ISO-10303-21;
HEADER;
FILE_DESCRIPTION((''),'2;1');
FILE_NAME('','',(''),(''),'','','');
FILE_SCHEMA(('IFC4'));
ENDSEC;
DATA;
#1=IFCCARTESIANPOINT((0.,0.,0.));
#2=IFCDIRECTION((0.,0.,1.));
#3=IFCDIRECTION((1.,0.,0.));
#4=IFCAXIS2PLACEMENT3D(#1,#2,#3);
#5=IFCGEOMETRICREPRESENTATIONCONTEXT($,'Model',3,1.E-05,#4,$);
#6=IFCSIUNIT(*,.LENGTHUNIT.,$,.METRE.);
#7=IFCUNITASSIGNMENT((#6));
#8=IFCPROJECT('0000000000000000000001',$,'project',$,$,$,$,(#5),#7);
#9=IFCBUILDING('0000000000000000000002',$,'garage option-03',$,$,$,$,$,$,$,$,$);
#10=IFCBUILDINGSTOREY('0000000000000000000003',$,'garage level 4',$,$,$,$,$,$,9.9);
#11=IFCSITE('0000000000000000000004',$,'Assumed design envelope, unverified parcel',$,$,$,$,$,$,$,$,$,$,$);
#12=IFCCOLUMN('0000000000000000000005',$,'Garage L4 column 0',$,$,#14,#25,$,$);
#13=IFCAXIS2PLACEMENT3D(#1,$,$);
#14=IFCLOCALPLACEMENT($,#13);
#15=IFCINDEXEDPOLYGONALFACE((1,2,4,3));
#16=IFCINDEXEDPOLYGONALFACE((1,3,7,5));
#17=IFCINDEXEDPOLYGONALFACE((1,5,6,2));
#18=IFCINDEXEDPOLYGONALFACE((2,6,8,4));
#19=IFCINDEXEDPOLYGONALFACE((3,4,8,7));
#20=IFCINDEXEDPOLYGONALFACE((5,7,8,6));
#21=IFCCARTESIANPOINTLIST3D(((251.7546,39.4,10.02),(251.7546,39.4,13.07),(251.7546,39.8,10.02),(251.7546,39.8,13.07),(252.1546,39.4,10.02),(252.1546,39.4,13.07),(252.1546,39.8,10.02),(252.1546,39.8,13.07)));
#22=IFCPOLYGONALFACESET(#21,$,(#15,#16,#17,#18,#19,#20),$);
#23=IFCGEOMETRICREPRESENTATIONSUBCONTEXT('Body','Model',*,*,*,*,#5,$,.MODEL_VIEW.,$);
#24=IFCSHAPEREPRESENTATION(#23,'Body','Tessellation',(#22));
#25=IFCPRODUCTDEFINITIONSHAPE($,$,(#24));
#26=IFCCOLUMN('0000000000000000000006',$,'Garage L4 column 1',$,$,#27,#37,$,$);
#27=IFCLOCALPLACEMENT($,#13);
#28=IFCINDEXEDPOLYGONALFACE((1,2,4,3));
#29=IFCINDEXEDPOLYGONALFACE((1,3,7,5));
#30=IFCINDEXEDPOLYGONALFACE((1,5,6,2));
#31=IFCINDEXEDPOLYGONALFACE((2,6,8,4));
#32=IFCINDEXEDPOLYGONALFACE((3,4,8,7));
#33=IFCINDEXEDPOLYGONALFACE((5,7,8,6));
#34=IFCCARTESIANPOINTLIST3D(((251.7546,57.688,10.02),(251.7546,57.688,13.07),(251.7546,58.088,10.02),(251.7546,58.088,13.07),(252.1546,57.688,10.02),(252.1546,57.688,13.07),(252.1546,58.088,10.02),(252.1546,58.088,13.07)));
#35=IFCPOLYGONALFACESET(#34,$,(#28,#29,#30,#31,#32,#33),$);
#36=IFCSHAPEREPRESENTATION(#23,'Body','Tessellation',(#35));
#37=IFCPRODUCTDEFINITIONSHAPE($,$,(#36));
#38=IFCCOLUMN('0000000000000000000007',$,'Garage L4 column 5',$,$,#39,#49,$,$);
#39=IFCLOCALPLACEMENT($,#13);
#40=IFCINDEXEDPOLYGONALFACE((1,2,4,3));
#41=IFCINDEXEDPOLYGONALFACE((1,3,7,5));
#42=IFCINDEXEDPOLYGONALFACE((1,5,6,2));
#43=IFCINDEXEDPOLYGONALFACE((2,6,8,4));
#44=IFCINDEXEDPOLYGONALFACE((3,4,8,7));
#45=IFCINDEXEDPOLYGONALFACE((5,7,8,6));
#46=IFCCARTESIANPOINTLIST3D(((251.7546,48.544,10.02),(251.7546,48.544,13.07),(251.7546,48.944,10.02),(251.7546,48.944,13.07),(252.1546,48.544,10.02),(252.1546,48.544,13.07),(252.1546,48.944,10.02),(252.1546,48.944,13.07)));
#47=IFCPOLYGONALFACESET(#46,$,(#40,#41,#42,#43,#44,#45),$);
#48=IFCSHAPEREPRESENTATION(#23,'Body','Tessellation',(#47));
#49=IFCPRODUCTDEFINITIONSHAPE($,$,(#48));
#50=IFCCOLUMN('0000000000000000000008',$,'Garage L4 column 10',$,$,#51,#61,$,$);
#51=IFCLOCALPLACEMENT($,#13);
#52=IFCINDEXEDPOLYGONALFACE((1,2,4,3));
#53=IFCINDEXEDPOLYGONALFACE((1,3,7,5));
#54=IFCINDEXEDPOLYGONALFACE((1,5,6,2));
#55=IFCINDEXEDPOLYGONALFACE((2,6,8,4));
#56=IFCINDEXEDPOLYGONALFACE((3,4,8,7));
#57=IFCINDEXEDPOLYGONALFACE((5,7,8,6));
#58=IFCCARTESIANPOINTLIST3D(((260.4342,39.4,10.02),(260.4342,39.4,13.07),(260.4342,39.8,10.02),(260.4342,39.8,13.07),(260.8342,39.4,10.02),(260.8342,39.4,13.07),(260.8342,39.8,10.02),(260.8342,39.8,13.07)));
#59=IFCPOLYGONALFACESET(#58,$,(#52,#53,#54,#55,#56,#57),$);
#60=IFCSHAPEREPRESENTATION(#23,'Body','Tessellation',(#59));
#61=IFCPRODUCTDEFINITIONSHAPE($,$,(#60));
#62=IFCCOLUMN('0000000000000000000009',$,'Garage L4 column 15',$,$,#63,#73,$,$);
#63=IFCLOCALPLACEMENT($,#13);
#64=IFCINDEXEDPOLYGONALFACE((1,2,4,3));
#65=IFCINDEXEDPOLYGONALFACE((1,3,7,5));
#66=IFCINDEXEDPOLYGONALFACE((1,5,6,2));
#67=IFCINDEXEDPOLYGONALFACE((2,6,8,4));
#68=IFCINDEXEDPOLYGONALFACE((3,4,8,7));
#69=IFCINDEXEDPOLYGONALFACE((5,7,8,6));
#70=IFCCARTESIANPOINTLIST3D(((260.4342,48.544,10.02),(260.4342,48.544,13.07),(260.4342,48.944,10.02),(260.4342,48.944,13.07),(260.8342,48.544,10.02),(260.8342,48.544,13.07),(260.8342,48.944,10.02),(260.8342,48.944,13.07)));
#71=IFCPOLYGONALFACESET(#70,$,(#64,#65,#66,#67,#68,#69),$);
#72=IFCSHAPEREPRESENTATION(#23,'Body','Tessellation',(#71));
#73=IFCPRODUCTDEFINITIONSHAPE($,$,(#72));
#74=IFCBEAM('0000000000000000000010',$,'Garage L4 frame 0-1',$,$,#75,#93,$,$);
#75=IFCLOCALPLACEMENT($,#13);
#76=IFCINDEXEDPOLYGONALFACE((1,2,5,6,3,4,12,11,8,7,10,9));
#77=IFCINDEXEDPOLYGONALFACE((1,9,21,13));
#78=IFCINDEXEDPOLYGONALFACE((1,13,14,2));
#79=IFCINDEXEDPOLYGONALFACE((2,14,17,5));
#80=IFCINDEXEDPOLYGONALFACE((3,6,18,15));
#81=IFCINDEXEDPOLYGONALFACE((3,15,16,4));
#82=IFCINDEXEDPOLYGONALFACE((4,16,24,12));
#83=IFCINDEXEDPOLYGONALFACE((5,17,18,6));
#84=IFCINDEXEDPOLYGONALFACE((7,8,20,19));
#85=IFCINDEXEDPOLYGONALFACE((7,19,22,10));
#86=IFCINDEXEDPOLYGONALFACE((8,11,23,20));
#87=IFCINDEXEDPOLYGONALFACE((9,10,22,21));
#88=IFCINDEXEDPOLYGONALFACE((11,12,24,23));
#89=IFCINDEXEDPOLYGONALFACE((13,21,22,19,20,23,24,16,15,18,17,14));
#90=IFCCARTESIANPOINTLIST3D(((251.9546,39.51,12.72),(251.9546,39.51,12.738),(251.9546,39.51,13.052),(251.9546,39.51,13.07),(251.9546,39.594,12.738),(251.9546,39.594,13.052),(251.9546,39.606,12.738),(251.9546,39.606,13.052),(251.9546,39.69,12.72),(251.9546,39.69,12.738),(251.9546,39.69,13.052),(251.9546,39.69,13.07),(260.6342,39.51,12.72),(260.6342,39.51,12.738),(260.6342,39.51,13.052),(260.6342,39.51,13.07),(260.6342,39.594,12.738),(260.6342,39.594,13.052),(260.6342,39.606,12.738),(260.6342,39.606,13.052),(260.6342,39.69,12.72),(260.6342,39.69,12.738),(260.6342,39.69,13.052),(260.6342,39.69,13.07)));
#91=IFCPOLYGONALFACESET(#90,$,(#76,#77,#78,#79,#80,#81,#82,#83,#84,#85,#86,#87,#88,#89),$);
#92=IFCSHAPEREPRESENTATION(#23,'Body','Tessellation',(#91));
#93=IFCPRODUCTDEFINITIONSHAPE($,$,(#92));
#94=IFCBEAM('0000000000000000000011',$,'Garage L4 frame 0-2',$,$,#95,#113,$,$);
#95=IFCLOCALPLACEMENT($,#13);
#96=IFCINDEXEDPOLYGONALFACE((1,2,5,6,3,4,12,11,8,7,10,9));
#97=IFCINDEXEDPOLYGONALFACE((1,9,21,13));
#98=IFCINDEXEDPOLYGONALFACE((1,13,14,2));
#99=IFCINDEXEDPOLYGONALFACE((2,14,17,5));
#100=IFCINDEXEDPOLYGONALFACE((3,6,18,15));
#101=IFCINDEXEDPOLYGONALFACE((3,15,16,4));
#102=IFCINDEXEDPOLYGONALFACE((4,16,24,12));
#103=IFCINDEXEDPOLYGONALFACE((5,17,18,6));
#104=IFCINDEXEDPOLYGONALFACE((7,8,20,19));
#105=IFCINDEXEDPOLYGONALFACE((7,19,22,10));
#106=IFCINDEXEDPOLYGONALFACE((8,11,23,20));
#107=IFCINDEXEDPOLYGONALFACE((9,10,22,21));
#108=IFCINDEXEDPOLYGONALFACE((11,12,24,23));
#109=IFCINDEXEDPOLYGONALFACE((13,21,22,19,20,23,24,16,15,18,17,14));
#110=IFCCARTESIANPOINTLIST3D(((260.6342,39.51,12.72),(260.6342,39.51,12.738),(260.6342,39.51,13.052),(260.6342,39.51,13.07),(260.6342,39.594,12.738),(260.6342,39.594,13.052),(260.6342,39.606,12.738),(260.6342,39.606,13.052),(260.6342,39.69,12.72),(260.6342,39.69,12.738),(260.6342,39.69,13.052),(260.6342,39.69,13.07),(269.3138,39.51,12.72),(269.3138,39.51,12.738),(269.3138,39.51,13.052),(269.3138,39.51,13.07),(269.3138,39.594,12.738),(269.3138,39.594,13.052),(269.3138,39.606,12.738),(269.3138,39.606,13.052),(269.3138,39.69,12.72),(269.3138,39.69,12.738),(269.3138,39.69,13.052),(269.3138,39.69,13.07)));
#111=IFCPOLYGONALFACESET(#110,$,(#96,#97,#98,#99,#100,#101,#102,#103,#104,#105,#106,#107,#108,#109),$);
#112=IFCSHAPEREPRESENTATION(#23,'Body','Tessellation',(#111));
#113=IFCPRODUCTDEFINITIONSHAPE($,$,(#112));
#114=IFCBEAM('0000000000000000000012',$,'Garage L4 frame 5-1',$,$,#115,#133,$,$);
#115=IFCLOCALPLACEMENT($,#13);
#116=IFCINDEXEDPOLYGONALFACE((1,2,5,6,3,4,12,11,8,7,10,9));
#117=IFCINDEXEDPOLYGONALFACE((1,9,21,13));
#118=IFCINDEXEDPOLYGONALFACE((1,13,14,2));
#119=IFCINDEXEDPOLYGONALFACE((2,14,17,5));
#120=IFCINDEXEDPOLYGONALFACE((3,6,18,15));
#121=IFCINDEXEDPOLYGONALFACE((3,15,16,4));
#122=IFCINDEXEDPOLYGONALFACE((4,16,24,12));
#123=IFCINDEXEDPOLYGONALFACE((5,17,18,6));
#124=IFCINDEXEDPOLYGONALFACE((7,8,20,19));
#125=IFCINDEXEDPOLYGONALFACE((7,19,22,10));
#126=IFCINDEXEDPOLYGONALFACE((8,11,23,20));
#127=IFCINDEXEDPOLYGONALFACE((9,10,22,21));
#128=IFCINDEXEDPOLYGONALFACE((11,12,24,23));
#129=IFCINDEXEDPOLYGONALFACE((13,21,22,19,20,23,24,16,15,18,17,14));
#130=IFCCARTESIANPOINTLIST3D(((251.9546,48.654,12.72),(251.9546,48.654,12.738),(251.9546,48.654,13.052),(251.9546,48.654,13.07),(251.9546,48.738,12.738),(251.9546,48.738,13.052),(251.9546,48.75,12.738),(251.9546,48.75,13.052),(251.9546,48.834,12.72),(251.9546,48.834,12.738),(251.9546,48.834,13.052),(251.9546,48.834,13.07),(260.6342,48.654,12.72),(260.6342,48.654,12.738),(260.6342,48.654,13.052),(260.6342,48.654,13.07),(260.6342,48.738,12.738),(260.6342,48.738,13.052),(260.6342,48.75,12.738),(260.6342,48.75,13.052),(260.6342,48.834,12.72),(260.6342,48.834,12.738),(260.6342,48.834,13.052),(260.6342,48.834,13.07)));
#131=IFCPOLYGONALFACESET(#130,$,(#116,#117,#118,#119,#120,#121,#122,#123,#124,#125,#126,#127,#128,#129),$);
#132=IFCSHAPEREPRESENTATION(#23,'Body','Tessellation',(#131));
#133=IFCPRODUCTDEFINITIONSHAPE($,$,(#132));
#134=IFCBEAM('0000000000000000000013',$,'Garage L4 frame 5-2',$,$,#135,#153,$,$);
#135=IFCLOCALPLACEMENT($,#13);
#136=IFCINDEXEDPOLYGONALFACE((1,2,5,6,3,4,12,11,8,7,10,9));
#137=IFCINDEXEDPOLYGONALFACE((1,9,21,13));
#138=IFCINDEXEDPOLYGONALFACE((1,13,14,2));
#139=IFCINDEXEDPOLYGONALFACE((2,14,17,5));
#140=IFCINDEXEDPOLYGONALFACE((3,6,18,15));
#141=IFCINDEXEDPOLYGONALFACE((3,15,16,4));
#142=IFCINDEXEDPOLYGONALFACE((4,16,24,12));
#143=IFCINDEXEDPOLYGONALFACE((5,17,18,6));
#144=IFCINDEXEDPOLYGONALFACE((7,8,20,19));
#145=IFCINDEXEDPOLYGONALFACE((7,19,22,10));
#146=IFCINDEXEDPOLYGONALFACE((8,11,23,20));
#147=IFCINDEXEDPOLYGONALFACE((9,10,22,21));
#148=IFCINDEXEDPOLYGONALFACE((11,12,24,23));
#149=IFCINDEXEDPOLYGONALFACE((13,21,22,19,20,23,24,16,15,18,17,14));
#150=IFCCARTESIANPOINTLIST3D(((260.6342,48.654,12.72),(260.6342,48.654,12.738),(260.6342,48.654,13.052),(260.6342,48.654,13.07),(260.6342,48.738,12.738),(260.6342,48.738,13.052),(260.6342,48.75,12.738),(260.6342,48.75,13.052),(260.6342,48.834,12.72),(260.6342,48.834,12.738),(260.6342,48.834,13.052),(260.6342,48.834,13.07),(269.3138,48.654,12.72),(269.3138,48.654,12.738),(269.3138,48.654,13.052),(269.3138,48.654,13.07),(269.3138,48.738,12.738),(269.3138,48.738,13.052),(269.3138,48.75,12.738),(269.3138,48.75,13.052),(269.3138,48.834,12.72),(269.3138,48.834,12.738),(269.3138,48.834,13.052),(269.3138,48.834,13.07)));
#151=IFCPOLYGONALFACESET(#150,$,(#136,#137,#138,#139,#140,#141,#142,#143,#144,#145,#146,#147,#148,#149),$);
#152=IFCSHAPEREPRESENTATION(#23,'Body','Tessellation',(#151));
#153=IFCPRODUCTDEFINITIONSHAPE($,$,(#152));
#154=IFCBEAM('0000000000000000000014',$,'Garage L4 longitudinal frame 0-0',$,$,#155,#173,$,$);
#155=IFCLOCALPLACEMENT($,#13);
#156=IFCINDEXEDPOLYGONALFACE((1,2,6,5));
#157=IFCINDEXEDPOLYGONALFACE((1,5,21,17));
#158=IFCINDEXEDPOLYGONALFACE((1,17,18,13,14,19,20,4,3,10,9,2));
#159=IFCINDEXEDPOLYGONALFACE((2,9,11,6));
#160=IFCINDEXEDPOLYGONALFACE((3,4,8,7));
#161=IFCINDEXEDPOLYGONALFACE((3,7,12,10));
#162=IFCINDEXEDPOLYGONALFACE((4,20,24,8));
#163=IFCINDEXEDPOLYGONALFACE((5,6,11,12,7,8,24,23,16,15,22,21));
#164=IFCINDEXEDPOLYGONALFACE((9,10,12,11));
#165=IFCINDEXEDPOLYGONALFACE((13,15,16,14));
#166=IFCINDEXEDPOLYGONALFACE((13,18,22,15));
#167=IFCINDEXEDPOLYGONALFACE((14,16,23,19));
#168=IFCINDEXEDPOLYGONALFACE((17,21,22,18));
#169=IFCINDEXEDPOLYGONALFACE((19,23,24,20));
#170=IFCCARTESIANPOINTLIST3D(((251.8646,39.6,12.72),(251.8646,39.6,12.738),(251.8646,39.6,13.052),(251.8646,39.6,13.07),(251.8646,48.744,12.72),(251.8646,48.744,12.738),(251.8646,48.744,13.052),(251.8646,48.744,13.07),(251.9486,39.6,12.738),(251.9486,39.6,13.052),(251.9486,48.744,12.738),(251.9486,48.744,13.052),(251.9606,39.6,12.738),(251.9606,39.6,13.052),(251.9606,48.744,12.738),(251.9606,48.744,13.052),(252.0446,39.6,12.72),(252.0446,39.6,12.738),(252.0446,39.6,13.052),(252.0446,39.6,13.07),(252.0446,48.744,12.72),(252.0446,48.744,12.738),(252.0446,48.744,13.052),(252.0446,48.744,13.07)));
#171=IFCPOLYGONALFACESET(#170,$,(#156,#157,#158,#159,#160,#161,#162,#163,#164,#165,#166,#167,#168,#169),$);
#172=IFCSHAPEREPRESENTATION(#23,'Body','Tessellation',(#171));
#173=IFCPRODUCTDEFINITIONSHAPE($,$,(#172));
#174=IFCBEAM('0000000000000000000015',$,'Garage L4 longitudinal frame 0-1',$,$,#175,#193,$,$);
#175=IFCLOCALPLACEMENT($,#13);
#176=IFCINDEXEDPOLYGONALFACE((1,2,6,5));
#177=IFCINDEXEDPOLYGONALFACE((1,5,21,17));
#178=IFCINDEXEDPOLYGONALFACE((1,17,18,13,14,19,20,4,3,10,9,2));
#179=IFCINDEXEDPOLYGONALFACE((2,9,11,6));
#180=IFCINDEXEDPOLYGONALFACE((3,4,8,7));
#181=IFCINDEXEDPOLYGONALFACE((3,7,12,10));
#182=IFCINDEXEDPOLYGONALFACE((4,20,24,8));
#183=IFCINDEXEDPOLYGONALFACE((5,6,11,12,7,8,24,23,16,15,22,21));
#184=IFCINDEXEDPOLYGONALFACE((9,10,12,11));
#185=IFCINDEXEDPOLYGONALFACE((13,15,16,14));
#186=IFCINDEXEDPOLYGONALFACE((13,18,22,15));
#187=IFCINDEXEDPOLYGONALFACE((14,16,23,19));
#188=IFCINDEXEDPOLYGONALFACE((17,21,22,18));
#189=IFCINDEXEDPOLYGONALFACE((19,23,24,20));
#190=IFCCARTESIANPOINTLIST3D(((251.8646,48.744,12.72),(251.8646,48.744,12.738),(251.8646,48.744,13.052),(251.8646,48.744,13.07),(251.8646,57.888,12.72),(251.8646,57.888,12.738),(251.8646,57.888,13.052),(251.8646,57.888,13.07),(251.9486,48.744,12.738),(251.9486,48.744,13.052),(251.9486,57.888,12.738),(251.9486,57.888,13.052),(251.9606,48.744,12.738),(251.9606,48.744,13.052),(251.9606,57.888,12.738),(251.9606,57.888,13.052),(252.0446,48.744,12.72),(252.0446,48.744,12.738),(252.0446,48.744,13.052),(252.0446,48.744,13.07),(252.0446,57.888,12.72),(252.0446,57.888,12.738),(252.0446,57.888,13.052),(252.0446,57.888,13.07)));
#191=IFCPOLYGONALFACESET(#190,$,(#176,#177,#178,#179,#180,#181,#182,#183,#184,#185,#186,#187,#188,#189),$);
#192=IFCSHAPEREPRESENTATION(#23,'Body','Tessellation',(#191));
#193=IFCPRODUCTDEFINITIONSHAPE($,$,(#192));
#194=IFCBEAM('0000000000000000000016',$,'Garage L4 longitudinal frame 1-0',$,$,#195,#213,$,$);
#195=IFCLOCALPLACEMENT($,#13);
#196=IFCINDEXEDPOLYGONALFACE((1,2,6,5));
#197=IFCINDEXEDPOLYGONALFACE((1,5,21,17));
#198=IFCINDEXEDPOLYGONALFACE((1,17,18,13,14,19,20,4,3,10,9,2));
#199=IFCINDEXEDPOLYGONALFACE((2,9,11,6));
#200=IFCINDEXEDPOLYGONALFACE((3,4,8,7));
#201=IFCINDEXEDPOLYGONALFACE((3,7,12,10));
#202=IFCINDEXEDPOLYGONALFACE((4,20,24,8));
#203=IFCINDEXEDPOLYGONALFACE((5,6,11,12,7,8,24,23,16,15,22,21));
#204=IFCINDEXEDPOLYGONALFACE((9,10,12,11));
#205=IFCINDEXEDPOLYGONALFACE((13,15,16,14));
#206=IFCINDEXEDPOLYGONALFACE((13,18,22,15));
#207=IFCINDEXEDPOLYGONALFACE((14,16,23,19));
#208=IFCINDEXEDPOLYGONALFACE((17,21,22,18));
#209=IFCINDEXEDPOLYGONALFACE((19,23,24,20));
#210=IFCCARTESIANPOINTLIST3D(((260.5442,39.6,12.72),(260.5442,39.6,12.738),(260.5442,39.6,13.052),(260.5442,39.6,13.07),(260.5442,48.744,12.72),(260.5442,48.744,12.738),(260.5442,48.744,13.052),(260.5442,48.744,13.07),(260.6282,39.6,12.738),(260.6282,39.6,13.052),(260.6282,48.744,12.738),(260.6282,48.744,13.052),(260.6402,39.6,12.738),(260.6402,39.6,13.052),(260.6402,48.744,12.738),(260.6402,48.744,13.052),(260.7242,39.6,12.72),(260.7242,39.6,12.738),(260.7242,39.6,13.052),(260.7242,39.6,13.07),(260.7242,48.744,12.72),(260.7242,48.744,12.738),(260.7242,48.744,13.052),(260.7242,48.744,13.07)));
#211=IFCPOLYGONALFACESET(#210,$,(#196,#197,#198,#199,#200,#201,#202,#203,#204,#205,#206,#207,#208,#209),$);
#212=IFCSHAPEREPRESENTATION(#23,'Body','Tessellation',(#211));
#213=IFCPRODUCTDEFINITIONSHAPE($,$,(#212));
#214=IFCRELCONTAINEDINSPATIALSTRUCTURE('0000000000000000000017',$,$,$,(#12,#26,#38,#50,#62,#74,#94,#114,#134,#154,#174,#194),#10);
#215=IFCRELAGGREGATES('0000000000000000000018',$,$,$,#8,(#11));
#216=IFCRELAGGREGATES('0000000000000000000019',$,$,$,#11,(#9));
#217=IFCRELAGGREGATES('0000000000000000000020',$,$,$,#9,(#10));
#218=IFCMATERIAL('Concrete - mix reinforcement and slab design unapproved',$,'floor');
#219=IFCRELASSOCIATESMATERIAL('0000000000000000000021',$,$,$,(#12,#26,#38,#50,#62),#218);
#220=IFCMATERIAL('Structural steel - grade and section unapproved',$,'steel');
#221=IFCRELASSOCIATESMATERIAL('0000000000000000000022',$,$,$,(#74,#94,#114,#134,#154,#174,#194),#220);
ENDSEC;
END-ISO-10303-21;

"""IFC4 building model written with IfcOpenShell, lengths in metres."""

from ifc_helpers import new_model, si_unit, frame, origin_with_axes, place, context, subcontext, project, spatial, rectangle, i_section, extrude, material, element, save


model = new_model("IFC4")

# Units and contexts
model_context = context("Model", 3, precision=1e-05, world=origin_with_axes())
body_context = subcontext(model_context, "Body", "Model", "MODEL_VIEW")
ifc_project = project(units=[si_unit("LENGTHUNIT", "METRE")], contexts=[model_context])

# Site, building, storey
site = spatial("IfcSite", under=ifc_project, Name="Assumed design envelope, unverified parcel")
building = spatial("IfcBuilding", under=site, Name="garage option-03")
storey = spatial("IfcBuildingStorey", under=building, Name="garage level 4", Elevation=9.9)

# Columns
ifc_material_1 = material(Name="Concrete - mix reinforcement and slab design unapproved", Category="floor")
for number, where, z_axis, x_axis, name in (
    (1, (251.9546, 39.6, 10.02), (0.0, 0.0, 1.0), (1.0, 0.0, 0.0), "Garage L4 column 0"),
    (2, (251.9546, 57.888, 10.02), (0.0, 0.0, 1.0), (1.0, 0.0, 0.0), "Garage L4 column 1"),
    (3, (251.9546, 48.744, 10.02), (0.0, 0.0, 1.0), (1.0, 0.0, 0.0), "Garage L4 column 5"),
    (4, (260.6342, 39.6, 10.02), (0.0, 0.0, 1.0), (1.0, 0.0, 0.0), "Garage L4 column 10"),
    (5, (260.6342, 48.744, 10.02), (0.0, 0.0, 1.0), (1.0, 0.0, 0.0), "Garage L4 column 15"),
):
    element("IfcColumn", number, at=place(None, frame(where, z_axis=z_axis, x_axis=x_axis)), inside=storey, material=ifc_material_1, Name=name, context=body_context, shape_type="SweptSolid", body=[
        extrude(rectangle(XDim=0.4, YDim=0.4), origin_with_axes(), (0.0, 0.0, 1.0), 3.05),
    ])

# Beams
ifc_material_2 = material(Name="Structural steel - grade and section unapproved", Category="steel")
beam_1_placement = place(None, frame((251.9546, 39.6, 12.895), z_axis=(1.0, 0.0, 0.0), x_axis=(0.0, 1.0, 0.0)))
element("IfcBeam", 6, at=beam_1_placement, inside=storey, material=ifc_material_2, Name="Garage L4 frame 0-1", context=body_context, shape_type="SweptSolid", body=[
    extrude(i_section(OverallWidth=0.18, OverallDepth=0.35, WebThickness=0.012, FlangeThickness=0.018, FilletRadius=0.0), origin_with_axes(), (0.0, 0.0, 1.0), 8.6796),
])
beam_2_placement = place(None, frame((260.6342, 39.6, 12.895), z_axis=(1.0, 0.0, 0.0), x_axis=(0.0, 1.0, 0.0)))
element("IfcBeam", 7, at=beam_2_placement, inside=storey, material=ifc_material_2, Name="Garage L4 frame 0-2", context=body_context, shape_type="SweptSolid", body=[
    extrude(i_section(OverallWidth=0.18, OverallDepth=0.35, WebThickness=0.012, FlangeThickness=0.018, FilletRadius=0.0), origin_with_axes(), (0.0, 0.0, 1.0), 8.6796),
])
beam_3_placement = place(None, frame((251.9546, 48.744, 12.895), z_axis=(1.0, 0.0, 0.0), x_axis=(0.0, 1.0, 0.0)))
element("IfcBeam", 8, at=beam_3_placement, inside=storey, material=ifc_material_2, Name="Garage L4 frame 5-1", context=body_context, shape_type="SweptSolid", body=[
    extrude(i_section(OverallWidth=0.18, OverallDepth=0.35, WebThickness=0.012, FlangeThickness=0.018, FilletRadius=0.0), origin_with_axes(), (0.0, 0.0, 1.0), 8.6796),
])
beam_4_placement = place(None, frame((260.6342, 48.744, 12.895), z_axis=(1.0, 0.0, 0.0), x_axis=(0.0, 1.0, 0.0)))
element("IfcBeam", 9, at=beam_4_placement, inside=storey, material=ifc_material_2, Name="Garage L4 frame 5-2", context=body_context, shape_type="SweptSolid", body=[
    extrude(i_section(OverallWidth=0.18, OverallDepth=0.35, WebThickness=0.012, FlangeThickness=0.018, FilletRadius=0.0), origin_with_axes(), (0.0, 0.0, 1.0), 8.6796),
])
for number, where, z_axis, x_axis, name in (
    (10, (251.9546, 39.6, 12.895), (0.0, 1.0, 0.0), (-1.0, 0.0, 0.0), "Garage L4 longitudinal frame 0-0"),
    (11, (251.9546, 48.744, 12.895), (0.0, 1.0, 0.0), (-1.0, 0.0, 0.0), "Garage L4 longitudinal frame 0-1"),
    (12, (260.6342, 39.6, 12.895), (0.0, 1.0, 0.0), (-1.0, 0.0, 0.0), "Garage L4 longitudinal frame 1-0"),
):
    element("IfcBeam", number, at=place(None, frame(where, z_axis=z_axis, x_axis=x_axis)), inside=storey, material=ifc_material_2, Name=name, context=body_context, shape_type="SweptSolid", body=[
        extrude(i_section(OverallWidth=0.18, OverallDepth=0.35, WebThickness=0.012, FlangeThickness=0.018, FilletRadius=0.0), origin_with_axes(), (0.0, 0.0, 1.0), 9.144),
    ])

save(model, "model.ifc")
